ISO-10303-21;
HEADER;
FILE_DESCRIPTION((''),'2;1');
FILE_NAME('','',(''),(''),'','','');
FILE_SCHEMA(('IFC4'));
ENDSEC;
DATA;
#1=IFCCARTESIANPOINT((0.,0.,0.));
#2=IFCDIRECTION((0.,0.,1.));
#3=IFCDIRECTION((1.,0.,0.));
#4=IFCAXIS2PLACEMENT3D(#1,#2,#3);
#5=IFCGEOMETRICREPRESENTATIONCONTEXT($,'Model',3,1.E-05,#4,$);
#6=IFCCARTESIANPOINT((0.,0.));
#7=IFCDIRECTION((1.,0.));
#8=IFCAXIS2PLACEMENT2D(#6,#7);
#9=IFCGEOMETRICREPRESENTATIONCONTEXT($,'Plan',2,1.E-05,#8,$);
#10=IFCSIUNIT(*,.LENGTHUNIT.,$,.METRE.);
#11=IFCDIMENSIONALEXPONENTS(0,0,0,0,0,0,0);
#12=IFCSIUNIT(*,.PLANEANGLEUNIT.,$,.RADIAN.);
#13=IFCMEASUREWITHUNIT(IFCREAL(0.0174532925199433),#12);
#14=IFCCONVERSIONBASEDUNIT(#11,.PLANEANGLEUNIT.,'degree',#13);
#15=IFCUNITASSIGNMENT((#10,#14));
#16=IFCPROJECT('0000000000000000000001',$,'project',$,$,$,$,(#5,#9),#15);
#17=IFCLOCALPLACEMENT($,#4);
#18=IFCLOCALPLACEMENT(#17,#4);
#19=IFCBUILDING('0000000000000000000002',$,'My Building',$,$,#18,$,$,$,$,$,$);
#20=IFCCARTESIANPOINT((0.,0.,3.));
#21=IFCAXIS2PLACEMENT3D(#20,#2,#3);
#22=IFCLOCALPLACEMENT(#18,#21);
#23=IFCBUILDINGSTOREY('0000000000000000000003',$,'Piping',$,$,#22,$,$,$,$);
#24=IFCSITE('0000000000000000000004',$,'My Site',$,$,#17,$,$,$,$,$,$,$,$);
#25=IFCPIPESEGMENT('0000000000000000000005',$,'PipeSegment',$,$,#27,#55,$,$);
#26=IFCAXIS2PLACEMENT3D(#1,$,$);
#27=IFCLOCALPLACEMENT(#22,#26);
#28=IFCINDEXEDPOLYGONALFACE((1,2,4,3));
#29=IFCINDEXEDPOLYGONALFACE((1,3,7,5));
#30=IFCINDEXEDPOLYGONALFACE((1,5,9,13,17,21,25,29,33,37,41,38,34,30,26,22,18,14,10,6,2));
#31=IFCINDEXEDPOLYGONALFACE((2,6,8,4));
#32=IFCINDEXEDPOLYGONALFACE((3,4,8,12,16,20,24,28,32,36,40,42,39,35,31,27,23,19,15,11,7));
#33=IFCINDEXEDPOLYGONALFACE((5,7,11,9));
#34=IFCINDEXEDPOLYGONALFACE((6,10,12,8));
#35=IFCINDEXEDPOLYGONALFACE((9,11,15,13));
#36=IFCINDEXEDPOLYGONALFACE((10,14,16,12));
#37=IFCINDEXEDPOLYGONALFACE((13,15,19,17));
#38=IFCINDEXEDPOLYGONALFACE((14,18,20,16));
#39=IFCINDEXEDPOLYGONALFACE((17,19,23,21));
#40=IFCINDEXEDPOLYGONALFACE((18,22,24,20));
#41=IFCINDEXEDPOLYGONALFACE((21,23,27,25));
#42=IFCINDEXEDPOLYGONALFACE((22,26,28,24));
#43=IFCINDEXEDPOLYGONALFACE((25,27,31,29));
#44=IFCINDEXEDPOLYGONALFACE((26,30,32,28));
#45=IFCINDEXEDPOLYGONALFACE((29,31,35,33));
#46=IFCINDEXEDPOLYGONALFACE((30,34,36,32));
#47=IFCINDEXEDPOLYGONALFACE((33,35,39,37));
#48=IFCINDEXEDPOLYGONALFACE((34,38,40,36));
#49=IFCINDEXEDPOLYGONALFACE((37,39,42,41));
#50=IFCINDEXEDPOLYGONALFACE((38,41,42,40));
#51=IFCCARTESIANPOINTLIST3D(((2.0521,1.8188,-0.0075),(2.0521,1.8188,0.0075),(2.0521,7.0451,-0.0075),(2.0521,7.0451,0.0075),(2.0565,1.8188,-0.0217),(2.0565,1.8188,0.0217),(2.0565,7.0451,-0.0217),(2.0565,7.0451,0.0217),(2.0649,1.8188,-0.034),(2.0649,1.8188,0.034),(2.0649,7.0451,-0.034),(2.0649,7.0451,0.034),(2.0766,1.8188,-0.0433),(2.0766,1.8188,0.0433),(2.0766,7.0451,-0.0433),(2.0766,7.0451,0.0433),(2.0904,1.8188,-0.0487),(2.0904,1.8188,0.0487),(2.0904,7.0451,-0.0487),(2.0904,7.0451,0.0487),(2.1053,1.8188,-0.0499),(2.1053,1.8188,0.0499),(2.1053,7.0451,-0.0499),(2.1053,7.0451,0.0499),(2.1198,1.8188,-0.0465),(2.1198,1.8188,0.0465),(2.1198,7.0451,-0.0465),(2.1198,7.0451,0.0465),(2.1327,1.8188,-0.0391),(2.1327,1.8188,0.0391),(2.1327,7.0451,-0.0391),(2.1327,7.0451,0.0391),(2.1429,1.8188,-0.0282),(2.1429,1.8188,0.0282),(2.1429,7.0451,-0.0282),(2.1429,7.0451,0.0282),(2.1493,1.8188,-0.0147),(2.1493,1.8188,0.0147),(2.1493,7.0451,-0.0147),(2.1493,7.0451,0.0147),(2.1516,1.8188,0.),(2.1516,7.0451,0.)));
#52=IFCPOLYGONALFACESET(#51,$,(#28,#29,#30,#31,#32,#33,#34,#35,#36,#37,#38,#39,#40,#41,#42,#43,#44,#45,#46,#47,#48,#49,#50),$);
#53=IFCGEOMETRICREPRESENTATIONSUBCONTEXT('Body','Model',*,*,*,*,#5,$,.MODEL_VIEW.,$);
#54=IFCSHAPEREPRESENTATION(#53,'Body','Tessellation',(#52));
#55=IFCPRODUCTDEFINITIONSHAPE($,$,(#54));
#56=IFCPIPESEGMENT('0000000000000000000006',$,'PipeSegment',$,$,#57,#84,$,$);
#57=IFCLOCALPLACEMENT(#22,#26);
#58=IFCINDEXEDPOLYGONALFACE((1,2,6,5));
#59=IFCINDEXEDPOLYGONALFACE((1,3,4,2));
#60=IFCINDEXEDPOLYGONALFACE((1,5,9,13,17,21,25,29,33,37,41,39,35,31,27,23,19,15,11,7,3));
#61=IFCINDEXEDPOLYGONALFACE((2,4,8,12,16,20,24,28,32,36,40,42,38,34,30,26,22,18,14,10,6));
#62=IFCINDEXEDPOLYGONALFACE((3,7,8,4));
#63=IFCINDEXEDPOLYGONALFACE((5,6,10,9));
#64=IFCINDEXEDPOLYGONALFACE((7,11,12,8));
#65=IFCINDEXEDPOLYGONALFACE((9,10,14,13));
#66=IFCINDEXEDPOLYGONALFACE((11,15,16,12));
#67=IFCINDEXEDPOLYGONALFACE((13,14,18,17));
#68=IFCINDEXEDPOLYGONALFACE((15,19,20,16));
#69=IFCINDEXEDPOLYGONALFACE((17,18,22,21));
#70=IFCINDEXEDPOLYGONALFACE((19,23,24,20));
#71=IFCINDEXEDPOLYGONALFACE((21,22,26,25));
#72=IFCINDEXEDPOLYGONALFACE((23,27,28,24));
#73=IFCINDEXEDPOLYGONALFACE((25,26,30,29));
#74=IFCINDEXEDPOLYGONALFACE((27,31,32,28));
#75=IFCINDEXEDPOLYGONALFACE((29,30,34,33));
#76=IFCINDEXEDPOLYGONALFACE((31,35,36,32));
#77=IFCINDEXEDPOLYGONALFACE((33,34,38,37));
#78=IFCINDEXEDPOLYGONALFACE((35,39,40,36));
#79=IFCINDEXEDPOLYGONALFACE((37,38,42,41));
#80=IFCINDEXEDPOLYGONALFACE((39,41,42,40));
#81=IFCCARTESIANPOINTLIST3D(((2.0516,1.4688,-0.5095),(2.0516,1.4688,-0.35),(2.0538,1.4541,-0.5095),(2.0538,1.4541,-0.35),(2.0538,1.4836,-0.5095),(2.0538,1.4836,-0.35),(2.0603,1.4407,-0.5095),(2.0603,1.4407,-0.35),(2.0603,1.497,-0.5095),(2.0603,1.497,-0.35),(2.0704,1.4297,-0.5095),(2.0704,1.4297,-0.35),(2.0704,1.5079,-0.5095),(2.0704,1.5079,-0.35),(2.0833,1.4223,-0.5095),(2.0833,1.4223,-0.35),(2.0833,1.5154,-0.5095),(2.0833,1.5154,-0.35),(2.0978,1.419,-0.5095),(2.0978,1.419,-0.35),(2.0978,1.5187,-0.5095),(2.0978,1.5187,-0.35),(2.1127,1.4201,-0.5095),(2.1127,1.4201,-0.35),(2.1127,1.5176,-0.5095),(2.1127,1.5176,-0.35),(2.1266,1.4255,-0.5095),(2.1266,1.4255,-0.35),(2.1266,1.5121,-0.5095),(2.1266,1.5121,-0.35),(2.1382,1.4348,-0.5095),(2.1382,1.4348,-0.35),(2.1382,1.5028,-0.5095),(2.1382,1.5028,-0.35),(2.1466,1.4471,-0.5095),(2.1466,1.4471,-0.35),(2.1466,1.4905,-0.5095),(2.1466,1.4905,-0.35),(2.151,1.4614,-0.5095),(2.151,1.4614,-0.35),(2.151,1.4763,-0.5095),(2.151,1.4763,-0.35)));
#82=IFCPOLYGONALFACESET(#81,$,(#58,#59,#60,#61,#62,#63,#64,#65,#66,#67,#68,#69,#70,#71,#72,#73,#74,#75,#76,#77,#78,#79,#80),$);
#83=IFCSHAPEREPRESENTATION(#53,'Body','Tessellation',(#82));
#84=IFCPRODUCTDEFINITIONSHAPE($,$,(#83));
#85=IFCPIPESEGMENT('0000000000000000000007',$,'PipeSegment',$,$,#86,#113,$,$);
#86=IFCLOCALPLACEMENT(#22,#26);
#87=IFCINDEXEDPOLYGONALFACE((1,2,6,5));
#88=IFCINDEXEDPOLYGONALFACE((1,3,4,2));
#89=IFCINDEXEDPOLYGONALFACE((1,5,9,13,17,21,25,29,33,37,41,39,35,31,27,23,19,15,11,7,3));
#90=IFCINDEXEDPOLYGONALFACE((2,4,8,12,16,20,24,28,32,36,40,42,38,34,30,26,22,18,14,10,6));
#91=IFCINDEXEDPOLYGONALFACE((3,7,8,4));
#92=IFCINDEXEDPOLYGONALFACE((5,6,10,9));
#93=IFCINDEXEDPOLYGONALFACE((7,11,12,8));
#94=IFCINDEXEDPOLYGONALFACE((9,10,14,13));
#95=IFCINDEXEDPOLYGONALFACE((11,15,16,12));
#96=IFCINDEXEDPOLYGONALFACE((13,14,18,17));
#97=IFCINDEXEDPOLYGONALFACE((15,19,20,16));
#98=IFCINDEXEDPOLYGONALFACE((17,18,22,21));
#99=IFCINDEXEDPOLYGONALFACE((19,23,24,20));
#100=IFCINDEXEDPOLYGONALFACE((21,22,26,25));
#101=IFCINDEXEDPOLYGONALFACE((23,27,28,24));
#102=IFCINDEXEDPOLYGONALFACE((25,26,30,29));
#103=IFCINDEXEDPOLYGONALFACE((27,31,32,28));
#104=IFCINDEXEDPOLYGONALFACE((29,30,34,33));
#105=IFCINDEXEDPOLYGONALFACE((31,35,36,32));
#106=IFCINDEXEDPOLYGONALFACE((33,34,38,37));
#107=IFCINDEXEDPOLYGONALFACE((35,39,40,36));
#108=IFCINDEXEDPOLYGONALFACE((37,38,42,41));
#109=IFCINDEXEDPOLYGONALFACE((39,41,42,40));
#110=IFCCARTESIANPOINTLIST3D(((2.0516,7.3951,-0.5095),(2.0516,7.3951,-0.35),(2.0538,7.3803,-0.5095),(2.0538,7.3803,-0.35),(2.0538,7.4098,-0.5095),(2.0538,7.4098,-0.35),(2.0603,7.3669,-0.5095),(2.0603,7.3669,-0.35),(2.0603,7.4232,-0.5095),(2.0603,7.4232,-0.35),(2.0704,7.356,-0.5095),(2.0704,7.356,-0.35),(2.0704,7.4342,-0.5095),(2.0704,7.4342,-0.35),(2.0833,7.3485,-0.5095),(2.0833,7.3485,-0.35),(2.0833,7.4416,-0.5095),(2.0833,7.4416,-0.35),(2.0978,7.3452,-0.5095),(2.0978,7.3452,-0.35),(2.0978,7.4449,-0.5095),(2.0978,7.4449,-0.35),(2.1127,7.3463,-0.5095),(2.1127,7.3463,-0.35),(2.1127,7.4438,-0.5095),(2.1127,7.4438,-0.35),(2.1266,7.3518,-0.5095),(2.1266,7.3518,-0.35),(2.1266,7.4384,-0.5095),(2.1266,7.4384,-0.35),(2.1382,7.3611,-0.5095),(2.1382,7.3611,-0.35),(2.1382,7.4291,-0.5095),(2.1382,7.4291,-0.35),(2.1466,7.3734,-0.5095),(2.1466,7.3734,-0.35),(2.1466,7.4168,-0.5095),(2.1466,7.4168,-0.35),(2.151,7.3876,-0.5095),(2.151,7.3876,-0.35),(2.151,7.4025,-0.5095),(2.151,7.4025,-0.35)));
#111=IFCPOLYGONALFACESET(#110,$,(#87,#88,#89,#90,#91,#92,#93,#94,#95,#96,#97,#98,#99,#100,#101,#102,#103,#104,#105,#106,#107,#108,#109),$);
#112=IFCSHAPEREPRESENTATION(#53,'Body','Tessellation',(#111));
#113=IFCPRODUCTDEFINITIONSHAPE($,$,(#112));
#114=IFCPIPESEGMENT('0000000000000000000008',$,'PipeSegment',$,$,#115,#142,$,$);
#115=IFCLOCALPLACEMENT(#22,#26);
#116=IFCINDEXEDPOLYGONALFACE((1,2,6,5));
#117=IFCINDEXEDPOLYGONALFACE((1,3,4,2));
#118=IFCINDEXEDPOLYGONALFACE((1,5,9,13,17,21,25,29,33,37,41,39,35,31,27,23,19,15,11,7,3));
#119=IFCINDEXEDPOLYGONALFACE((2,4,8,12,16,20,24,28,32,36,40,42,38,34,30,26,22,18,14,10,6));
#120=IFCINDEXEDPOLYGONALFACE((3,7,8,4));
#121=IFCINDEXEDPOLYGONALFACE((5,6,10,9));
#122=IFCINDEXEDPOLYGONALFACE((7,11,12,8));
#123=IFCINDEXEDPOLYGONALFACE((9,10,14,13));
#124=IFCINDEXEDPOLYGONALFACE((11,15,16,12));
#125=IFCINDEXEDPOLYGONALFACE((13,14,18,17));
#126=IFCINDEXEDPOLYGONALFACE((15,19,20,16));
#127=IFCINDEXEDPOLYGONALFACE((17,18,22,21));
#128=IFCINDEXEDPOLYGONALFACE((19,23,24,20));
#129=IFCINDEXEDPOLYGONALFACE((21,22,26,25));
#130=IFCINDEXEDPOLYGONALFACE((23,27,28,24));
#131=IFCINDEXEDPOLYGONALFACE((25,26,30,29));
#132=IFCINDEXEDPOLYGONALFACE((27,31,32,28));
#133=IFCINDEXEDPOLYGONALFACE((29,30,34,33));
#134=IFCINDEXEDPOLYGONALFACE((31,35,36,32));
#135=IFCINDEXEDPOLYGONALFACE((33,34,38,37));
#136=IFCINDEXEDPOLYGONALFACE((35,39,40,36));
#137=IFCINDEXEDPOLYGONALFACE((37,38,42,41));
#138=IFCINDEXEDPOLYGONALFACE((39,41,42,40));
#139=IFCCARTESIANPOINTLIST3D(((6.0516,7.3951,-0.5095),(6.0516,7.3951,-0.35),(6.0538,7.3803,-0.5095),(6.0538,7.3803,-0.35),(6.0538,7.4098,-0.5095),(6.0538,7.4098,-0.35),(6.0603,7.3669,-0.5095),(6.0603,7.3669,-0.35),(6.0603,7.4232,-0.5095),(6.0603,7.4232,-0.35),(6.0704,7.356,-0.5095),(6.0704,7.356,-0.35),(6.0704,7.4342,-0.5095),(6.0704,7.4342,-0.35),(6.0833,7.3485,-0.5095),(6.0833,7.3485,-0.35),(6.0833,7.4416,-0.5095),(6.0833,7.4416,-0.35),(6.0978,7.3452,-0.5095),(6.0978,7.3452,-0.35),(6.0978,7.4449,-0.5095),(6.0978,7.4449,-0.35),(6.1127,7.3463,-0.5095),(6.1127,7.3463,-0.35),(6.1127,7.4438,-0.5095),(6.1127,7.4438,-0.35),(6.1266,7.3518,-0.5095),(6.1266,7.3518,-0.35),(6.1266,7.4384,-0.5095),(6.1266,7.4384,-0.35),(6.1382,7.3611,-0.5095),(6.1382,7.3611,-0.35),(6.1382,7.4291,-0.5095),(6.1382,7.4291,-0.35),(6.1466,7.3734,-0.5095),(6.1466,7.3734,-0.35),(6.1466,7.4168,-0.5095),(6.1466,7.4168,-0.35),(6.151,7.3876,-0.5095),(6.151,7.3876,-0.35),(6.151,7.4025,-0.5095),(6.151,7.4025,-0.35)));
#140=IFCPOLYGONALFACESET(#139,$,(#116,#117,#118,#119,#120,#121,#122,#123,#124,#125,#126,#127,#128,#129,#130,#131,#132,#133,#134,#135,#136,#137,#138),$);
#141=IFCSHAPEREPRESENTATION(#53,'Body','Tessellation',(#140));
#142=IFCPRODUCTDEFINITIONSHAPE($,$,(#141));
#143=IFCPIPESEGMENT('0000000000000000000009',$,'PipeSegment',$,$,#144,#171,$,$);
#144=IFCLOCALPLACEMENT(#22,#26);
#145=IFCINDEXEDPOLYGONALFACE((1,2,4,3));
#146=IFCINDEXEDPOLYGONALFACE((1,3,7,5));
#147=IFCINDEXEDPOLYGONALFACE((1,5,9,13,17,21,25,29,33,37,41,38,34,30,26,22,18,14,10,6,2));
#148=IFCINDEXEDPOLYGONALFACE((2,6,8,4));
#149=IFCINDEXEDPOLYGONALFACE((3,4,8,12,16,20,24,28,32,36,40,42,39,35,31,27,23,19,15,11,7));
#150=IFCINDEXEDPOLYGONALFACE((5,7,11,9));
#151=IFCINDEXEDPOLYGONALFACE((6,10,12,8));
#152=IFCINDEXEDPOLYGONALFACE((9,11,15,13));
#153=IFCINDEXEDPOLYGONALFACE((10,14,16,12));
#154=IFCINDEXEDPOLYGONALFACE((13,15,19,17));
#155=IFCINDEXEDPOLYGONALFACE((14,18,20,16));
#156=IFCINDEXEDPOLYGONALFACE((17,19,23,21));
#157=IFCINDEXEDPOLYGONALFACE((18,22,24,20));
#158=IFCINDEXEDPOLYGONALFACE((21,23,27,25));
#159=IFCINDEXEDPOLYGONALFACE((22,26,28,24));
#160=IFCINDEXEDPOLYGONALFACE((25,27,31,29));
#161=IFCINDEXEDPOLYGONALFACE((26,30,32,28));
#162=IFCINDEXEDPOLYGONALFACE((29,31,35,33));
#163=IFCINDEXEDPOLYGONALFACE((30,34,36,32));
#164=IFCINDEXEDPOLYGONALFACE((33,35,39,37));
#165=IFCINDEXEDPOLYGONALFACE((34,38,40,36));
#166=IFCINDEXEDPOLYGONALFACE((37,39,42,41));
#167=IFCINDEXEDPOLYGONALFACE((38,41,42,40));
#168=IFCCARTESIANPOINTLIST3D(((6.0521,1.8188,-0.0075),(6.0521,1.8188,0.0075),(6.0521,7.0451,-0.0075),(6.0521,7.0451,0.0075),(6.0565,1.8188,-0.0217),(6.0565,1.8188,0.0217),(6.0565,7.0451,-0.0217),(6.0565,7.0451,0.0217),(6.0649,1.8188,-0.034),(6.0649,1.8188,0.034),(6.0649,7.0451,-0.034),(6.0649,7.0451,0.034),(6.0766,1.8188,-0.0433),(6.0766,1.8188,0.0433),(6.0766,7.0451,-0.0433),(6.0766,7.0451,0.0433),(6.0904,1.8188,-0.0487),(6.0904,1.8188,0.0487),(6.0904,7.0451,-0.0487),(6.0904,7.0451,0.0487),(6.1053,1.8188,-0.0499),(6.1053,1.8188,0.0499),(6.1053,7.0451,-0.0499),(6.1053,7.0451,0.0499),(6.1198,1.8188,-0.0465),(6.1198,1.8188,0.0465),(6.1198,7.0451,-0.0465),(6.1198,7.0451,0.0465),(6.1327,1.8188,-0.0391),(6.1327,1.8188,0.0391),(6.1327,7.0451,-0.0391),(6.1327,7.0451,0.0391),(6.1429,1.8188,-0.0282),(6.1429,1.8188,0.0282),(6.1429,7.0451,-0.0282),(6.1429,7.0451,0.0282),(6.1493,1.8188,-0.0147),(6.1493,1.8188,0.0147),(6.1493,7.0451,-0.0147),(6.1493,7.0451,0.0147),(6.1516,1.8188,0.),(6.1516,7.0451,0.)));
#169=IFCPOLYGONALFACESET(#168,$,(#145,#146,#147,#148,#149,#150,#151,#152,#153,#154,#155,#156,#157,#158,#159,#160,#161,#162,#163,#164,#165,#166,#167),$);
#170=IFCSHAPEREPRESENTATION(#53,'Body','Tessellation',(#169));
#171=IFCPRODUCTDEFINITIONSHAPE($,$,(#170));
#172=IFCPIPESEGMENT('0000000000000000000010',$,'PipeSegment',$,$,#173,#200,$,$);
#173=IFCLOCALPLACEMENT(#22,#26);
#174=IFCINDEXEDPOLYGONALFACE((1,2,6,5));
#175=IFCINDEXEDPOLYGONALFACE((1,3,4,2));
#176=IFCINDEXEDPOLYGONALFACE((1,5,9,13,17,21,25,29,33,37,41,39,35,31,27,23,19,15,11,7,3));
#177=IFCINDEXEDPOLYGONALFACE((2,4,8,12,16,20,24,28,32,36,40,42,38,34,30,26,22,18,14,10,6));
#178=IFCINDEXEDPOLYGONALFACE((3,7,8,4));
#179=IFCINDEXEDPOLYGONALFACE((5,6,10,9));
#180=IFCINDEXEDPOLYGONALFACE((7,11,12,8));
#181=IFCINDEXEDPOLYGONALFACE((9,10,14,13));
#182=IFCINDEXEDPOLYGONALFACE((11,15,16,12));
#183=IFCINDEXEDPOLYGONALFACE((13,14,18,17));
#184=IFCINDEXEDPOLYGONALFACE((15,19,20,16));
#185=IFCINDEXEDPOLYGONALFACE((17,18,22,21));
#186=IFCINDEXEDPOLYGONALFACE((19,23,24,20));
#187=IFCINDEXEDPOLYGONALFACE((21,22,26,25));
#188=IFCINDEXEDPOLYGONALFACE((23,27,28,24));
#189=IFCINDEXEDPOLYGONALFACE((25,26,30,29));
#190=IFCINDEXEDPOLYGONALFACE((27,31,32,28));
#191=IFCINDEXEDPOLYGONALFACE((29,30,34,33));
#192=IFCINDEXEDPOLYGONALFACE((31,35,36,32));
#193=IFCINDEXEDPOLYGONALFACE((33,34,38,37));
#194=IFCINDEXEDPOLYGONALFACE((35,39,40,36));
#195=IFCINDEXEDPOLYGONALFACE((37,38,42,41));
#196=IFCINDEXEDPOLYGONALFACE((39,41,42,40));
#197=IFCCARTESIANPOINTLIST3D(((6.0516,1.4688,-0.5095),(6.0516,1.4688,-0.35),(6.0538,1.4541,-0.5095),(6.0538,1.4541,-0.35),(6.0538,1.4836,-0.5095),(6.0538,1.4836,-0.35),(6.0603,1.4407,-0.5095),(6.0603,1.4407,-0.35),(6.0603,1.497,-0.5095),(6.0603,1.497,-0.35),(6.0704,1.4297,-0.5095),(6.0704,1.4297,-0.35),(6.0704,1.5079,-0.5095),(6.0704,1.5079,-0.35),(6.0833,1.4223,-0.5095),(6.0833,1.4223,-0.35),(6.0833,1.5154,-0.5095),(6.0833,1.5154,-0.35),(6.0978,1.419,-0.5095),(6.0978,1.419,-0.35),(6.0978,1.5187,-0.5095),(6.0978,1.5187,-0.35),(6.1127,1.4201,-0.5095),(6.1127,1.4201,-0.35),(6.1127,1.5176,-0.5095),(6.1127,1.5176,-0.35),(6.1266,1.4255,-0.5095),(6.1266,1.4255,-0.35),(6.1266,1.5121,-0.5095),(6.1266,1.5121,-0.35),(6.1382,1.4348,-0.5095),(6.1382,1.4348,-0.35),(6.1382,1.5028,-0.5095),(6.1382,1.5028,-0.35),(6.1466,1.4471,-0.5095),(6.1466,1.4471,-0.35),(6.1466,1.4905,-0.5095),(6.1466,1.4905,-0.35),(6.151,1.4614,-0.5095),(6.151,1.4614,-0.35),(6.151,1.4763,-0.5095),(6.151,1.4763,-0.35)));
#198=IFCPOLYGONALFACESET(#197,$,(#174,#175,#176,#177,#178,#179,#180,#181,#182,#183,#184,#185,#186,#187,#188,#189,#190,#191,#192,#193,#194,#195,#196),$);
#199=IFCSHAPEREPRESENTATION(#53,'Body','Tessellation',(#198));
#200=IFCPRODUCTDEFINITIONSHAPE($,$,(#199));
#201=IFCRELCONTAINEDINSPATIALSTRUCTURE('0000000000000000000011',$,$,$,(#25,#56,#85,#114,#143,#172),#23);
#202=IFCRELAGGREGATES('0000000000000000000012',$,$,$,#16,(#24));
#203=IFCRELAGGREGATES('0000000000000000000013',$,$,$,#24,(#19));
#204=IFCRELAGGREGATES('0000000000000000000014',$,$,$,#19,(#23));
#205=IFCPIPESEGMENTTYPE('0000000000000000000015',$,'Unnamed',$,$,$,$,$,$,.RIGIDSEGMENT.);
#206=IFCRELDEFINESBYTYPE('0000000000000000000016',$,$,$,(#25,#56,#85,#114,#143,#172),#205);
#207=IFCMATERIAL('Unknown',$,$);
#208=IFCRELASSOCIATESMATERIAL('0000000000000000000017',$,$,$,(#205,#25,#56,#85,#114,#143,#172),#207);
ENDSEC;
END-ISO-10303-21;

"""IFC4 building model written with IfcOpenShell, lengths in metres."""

from ifc_helpers import new_model, entity, si_unit, converted_unit, frame, origin_with_axes, origin_2d_with_axis, place, context, subcontext, project, spatial, circle, extrude, material, material_profile, profile_set, profile_usage, type_object, element, save


model = new_model("IFC4")

# Units and contexts
model_context = context("Model", 3, precision=1e-05, world=origin_with_axes())
plan_context = context("Plan", 2, precision=1e-05, world=origin_2d_with_axis())
body_context = subcontext(model_context, "Body", "Model", "MODEL_VIEW")
ifc_project = project(units=[si_unit("LENGTHUNIT", "METRE"), converted_unit("PLANEANGLEUNIT", "degree", entity("IfcReal", 0.0174532925199433), si_unit("PLANEANGLEUNIT", "RADIAN"), dimensions=[0, 0, 0, 0, 0, 0, 0])], contexts=[model_context, plan_context])

# Site, building, storey
site_placement = place(None, origin_with_axes())
site = spatial("IfcSite", under=ifc_project, at=site_placement, Name="My Site")
building_placement = place(site_placement, origin_with_axes())
building = spatial("IfcBuilding", under=site, at=building_placement, Name="My Building")
storey_placement = place(building_placement, frame((0.0, 0.0, 3.0), z_axis=(0.0, 0.0, 1.0), x_axis=(1.0, 0.0, 0.0)))
storey = spatial("IfcBuildingStorey", under=building, at=storey_placement, Name="Piping")

# Pipe segments
ifc_material = material(Name="Unknown")
ifc_material_profile = material_profile(ifc_material, circle(Radius=0.05))
ifc_profile_set = profile_set([ifc_material_profile])
ifc_profile_usage_1 = profile_usage(ifc_profile_set, cardinal=5)
pipe_segment_type = type_object("IfcPipeSegmentType", Name="Unnamed", PredefinedType="RIGIDSEGMENT", material=ifc_profile_set)
pipe_segment_1_placement = place(storey_placement, frame((2.1016, 1.8188, 0.0), z_axis=(0.0, 1.0, 0.0), x_axis=(1.0, 0.0, 0.0)))
element("IfcPipeSegment", 1, at=pipe_segment_1_placement, inside=storey, type_object=pipe_segment_type, material=ifc_profile_usage_1, Name="PipeSegment", context=body_context, shape_type="SweptSolid", body=[
    extrude(circle(Radius=0.05), origin_with_axes(), (0.0, 0.0, 1.0), 5.2262),
])
ifc_profile_usage_2 = profile_usage(ifc_profile_set, cardinal=5)
pipe_segment_2_placement = place(storey_placement, frame((2.1016, 1.4688, -0.35), z_axis=(0.0, 0.0, -1.0), x_axis=(-1.0, 0.0, 0.0)))
element("IfcPipeSegment", 2, at=pipe_segment_2_placement, inside=storey, type_object=pipe_segment_type, material=ifc_profile_usage_2, Name="PipeSegment", context=body_context, shape_type="SweptSolid", body=[
    extrude(circle(Radius=0.05), origin_with_axes(), (0.0, 0.0, 1.0), 0.1595),
])
ifc_profile_usage_3 = profile_usage(ifc_profile_set, cardinal=5)
pipe_segment_3_placement = place(storey_placement, frame((2.1016, 7.3951, -0.35), z_axis=(0.0, 0.0, -1.0), x_axis=(-1.0, 0.0, 0.0)))
element("IfcPipeSegment", 3, at=pipe_segment_3_placement, inside=storey, type_object=pipe_segment_type, material=ifc_profile_usage_3, Name="PipeSegment", context=body_context, shape_type="SweptSolid", body=[
    extrude(circle(Radius=0.05), origin_with_axes(), (0.0, 0.0, 1.0), 0.1595),
])
ifc_profile_usage_4 = profile_usage(ifc_profile_set, cardinal=5)
pipe_segment_4_placement = place(storey_placement, frame((6.1016, 7.3951, -0.35), z_axis=(0.0, 0.0, -1.0), x_axis=(-1.0, 0.0, 0.0)))
element("IfcPipeSegment", 4, at=pipe_segment_4_placement, inside=storey, type_object=pipe_segment_type, material=ifc_profile_usage_4, Name="PipeSegment", context=body_context, shape_type="SweptSolid", body=[
    extrude(circle(Radius=0.05), origin_with_axes(), (0.0, 0.0, 1.0), 0.1595),
])
ifc_profile_usage_5 = profile_usage(ifc_profile_set, cardinal=5)
pipe_segment_5_placement = place(storey_placement, frame((6.1016, 1.8188, 0.0), z_axis=(0.0, 1.0, 0.0), x_axis=(1.0, 0.0, 0.0)))
element("IfcPipeSegment", 5, at=pipe_segment_5_placement, inside=storey, type_object=pipe_segment_type, material=ifc_profile_usage_5, Name="PipeSegment", context=body_context, shape_type="SweptSolid", body=[
    extrude(circle(Radius=0.05), origin_with_axes(), (0.0, 0.0, 1.0), 5.2262),
])
ifc_profile_usage_6 = profile_usage(ifc_profile_set, cardinal=5)
pipe_segment_6_placement = place(storey_placement, frame((6.1016, 1.4688, -0.35), z_axis=(0.0, 0.0, -1.0), x_axis=(-1.0, 0.0, 0.0)))
element("IfcPipeSegment", 6, at=pipe_segment_6_placement, inside=storey, type_object=pipe_segment_type, material=ifc_profile_usage_6, Name="PipeSegment", context=body_context, shape_type="SweptSolid", body=[
    extrude(circle(Radius=0.05), origin_with_axes(), (0.0, 0.0, 1.0), 0.1595),
])

save(model, "model.ifc")
